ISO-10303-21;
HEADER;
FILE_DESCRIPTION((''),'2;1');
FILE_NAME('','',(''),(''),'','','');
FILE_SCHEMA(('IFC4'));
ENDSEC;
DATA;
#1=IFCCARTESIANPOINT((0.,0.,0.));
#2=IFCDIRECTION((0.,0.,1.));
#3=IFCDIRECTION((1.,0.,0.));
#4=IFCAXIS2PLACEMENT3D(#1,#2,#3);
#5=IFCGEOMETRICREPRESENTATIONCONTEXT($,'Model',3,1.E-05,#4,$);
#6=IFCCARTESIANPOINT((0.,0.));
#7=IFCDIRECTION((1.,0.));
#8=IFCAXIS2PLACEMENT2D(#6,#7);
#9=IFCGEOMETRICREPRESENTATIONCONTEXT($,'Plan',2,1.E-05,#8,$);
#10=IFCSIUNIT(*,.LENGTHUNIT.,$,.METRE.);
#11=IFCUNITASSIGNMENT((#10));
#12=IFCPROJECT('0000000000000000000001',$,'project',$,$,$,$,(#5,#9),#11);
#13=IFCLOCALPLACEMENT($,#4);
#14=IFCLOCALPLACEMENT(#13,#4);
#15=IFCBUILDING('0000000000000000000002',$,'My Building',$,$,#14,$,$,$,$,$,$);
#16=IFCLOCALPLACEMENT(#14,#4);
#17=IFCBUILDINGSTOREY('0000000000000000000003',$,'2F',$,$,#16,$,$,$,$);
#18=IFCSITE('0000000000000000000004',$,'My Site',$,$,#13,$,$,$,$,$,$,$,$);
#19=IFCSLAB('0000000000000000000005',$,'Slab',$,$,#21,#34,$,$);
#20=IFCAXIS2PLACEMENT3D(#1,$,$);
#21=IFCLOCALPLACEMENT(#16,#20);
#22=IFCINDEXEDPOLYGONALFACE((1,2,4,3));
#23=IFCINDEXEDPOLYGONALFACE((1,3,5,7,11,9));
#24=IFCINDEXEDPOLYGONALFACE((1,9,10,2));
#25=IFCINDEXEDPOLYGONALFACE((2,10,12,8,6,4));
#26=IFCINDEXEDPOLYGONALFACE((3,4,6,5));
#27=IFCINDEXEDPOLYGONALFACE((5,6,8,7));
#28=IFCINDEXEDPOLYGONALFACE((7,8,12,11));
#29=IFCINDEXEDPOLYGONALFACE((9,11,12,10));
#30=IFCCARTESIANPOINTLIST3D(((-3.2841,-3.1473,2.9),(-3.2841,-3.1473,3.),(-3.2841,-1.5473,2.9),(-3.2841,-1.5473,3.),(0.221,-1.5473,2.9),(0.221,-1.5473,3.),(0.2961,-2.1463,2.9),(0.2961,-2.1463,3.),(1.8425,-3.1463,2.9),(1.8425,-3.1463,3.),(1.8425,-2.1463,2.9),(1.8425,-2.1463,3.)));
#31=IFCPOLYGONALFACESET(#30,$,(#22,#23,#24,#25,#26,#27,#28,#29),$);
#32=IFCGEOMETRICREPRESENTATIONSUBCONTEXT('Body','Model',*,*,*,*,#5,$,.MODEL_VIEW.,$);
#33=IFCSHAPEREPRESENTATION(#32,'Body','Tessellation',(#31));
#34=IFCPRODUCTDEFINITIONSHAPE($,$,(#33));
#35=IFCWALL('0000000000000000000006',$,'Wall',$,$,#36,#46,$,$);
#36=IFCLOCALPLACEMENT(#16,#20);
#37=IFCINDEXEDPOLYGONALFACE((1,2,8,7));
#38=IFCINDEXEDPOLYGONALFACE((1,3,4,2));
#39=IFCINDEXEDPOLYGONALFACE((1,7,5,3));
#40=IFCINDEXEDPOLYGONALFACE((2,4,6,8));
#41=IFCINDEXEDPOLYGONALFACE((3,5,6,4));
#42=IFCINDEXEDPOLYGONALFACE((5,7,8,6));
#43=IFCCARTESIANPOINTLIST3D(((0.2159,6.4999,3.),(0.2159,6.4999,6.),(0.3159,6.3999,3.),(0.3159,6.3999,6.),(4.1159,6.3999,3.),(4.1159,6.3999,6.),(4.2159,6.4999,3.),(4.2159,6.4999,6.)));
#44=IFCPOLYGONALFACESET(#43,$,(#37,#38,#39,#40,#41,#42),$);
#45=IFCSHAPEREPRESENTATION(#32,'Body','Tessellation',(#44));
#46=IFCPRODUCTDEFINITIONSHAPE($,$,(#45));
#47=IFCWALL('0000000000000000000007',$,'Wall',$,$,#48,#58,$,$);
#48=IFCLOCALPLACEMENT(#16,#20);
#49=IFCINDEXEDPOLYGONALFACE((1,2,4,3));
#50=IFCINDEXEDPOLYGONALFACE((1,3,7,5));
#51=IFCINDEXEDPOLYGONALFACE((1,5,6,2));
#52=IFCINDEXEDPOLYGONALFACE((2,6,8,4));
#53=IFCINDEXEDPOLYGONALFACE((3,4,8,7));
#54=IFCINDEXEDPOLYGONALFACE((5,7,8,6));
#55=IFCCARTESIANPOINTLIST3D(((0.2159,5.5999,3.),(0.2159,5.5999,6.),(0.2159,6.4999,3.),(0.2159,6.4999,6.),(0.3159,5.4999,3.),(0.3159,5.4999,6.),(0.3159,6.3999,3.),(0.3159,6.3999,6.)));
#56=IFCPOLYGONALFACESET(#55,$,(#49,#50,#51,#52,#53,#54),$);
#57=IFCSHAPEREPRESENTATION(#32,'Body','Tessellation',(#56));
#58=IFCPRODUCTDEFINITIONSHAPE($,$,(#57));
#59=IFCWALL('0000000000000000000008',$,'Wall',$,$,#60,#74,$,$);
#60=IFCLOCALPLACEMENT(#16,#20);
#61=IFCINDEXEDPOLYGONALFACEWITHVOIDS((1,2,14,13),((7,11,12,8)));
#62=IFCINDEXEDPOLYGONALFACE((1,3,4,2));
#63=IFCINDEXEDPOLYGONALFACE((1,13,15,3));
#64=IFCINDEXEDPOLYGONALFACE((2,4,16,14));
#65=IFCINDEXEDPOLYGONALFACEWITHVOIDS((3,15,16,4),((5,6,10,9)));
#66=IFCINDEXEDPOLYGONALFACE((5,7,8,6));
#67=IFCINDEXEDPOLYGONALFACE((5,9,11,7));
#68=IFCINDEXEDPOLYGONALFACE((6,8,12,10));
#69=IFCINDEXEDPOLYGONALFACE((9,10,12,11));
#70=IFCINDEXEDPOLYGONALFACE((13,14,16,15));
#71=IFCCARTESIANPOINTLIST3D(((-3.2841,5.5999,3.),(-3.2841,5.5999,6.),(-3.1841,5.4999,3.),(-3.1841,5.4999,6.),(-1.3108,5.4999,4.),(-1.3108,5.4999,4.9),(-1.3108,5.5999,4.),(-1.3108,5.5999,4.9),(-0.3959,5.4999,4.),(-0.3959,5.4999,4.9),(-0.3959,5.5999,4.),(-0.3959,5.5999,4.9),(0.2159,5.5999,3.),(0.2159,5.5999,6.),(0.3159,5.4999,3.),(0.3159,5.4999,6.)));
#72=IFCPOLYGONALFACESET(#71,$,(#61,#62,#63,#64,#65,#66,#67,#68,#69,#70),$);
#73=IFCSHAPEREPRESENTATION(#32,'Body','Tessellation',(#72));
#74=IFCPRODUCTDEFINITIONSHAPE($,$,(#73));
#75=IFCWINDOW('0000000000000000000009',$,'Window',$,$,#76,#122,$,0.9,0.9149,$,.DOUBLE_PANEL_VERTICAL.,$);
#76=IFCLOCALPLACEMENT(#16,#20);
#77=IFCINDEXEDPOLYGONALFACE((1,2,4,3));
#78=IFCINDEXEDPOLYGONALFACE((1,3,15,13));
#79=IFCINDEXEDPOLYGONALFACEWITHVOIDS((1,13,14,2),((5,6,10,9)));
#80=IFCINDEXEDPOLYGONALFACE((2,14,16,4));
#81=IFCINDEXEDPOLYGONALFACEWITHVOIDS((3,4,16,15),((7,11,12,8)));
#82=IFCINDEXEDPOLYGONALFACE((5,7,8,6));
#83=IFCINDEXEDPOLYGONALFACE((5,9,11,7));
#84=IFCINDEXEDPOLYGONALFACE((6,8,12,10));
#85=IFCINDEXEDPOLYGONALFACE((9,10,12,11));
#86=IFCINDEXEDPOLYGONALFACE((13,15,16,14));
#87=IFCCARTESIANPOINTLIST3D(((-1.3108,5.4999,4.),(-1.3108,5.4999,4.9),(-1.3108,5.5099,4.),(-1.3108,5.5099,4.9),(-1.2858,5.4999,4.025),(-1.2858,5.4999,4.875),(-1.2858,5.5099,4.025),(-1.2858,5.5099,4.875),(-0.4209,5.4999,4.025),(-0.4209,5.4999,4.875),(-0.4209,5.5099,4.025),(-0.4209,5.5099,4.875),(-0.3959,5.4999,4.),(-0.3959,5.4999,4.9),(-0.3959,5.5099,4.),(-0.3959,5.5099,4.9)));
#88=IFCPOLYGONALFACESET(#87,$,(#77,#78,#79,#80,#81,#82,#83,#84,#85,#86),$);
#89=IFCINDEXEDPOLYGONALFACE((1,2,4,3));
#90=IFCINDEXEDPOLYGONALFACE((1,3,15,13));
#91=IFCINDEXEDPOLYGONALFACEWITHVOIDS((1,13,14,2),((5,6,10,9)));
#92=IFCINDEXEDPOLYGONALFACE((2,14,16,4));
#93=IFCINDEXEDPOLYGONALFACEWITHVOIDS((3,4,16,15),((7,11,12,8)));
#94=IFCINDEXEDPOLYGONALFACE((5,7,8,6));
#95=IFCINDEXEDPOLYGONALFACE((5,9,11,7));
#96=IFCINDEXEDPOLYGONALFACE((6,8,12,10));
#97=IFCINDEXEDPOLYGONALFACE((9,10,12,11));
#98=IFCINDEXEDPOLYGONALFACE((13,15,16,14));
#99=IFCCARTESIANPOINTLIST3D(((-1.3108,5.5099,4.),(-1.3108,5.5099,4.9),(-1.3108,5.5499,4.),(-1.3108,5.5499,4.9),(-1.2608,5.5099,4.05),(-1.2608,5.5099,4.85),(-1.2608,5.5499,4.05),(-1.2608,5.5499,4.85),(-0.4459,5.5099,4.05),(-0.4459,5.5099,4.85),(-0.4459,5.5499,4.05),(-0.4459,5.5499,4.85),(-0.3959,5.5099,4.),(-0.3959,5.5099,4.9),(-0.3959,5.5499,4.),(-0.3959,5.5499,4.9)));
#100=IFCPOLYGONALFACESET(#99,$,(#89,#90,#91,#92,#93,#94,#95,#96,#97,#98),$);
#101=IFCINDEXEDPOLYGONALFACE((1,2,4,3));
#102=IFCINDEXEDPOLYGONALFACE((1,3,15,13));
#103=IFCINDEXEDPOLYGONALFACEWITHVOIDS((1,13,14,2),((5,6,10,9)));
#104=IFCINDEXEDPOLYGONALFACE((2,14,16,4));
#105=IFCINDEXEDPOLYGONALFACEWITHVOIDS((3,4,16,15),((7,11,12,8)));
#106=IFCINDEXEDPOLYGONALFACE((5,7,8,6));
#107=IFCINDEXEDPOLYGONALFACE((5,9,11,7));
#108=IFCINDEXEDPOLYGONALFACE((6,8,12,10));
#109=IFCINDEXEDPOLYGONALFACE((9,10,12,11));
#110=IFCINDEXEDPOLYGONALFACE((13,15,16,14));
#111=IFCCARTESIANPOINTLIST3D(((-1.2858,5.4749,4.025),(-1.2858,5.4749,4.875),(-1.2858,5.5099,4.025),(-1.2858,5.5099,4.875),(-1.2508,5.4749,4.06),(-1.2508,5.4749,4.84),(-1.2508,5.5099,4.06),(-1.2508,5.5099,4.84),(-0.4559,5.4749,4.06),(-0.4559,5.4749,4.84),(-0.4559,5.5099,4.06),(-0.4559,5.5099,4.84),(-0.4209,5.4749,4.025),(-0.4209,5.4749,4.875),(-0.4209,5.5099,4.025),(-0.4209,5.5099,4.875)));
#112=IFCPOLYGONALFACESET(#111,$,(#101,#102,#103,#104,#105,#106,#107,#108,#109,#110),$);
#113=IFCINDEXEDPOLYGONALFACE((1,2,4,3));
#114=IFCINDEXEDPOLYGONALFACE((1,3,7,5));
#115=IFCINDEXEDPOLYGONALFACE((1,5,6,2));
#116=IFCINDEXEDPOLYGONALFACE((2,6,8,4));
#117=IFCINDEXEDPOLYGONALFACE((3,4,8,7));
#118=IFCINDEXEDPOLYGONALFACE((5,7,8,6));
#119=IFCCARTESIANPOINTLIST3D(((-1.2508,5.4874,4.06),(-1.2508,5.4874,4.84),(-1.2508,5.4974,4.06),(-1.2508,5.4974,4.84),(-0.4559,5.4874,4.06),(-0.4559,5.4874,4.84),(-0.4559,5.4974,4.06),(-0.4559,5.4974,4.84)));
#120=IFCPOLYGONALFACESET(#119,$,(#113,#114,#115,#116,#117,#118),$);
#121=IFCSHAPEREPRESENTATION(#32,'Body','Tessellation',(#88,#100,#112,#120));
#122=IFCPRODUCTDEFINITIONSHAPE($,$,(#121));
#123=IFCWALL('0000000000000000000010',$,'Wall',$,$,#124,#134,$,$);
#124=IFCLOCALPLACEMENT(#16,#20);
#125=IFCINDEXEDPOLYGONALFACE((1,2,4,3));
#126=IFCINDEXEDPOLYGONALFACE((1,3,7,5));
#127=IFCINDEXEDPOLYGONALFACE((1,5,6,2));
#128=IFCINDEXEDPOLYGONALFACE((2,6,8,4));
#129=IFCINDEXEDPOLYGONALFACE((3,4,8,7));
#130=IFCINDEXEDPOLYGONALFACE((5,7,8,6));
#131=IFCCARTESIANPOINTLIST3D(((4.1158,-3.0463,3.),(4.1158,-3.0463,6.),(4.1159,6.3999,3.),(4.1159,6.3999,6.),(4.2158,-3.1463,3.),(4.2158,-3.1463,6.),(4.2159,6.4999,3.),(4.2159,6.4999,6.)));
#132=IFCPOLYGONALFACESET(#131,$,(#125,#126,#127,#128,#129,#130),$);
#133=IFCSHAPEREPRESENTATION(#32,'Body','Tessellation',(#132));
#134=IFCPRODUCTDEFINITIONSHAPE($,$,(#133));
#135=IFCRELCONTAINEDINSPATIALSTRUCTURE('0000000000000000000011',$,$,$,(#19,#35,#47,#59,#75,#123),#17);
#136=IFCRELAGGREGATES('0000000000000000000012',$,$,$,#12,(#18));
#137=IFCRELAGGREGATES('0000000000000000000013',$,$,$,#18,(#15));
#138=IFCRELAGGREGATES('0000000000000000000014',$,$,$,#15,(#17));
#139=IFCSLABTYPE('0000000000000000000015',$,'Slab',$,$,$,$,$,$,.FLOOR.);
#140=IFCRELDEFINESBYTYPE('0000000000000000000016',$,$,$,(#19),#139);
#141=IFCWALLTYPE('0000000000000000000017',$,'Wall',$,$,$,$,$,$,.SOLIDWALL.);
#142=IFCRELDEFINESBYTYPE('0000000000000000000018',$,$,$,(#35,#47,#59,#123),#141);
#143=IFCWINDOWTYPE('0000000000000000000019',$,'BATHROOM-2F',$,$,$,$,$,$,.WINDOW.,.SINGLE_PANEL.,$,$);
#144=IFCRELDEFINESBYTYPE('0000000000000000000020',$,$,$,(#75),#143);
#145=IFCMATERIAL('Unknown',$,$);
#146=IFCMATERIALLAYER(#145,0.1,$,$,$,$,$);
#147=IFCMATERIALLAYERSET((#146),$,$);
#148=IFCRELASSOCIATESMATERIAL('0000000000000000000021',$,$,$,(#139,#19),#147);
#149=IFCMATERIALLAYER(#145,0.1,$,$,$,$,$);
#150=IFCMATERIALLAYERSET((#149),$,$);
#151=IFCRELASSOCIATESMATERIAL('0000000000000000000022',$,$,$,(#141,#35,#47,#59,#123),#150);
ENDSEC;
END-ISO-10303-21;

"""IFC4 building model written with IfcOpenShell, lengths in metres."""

from ifc_helpers import new_model, entity, si_unit, frame, origin_with_axes, origin_2d_with_axis, place, context, subcontext, project, spatial, line, indexed_curve, outline, extrude, shape, source, transform, mapped, material, layer, layer_set, layer_usage, type_object, type_shapes, element, fill, save


model = new_model("IFC4")

# Units and contexts
model_context = context("Model", 3, precision=1e-05, world=origin_with_axes())
plan_context = context("Plan", 2, precision=1e-05, world=origin_2d_with_axis())
body_context_1 = subcontext(model_context, "Body", "Model", "MODEL_VIEW")
body_context_2 = subcontext(plan_context, "Body", "Plan", "PLAN_VIEW")
ifc_project = project(units=[si_unit("LENGTHUNIT", "METRE")], contexts=[model_context, plan_context])

# Site, building, storey
site_placement = place(None, origin_with_axes())
site = spatial("IfcSite", under=ifc_project, at=site_placement, Name="My Site")
building_placement = place(site_placement, origin_with_axes())
building = spatial("IfcBuilding", under=site, at=building_placement, Name="My Building")
storey_placement = place(building_placement, origin_with_axes())
storey = spatial("IfcBuildingStorey", under=building, at=storey_placement, Name="2F")

# Slab
ifc_material = material(Name="Unknown")
ifc_layer_1 = layer(ifc_material, 0.1)
ifc_layer_set_1 = layer_set([ifc_layer_1])
ifc_layer_usage_1 = layer_usage(ifc_layer_set_1, "AXIS3", "POSITIVE", -0.1)
slab_type = type_object("IfcSlabType", Name="Slab", PredefinedType="FLOOR", material=ifc_layer_set_1)
slab_placement = place(storey_placement, frame((-3.2841, -1.5473, 3.0), z_axis=(0.0, 0.0, 1.0), x_axis=(1.0, 0.0, 0.0)))
element("IfcSlab", 1, at=slab_placement, inside=storey, type_object=slab_type, material=ifc_layer_usage_1, Name="Slab", context=body_context_1, shape_type="SweptSolid", body=[
    extrude(outline(indexed_curve([(0.0, 0.0), (0.0, -1.6), (5.1266, -1.599), (5.1266, -0.599), (3.5803, -0.599), (3.5052, 0.0), (0.0, 0.0)])), frame((0.0, 0.0, -0.1), z_axis=(0.0, 0.0, 1.0), x_axis=(1.0, 0.0, 0.0)), (0.0, 0.0, 1.0), 0.1),
])

# Walls
ifc_layer_2 = layer(ifc_material, 0.1)
ifc_layer_set_2 = layer_set([ifc_layer_2])
ifc_layer_usage_2 = layer_usage(ifc_layer_set_2, "AXIS2", "POSITIVE", 0.0)
wall_type = type_object("IfcWallType", Name="Wall", PredefinedType="SOLIDWALL", material=ifc_layer_set_2)
wall_1_placement = place(storey_placement, frame((4.2159, 6.4999, 3.0), z_axis=(0.0, 0.0, 1.0), x_axis=(-1.0, 0.0, 0.0)))
element("IfcWall", 2, at=wall_1_placement, inside=storey, type_object=wall_type, material=ifc_layer_usage_2, Name="Wall", context=body_context_1, shape_type="SweptSolid", body=[
    extrude(outline(indexed_curve([(0.0, 0.0), (0.1, 0.1), (3.9, 0.1), (4.0, 0.0)], segments=[line(1, 2, 3, 4, 1)])), origin_with_axes(), (0.0, 0.0, 1.0), 3.0),
])
ifc_layer_usage_3 = layer_usage(ifc_layer_set_2, "AXIS2", "POSITIVE", 0.0)
wall_2_placement = place(storey_placement, frame((0.2159, 6.4999, 3.0), z_axis=(0.0, 0.0, 1.0), x_axis=(0.0, -1.0, 0.0)))
element("IfcWall", 3, at=wall_2_placement, inside=storey, type_object=wall_type, material=ifc_layer_usage_3, Name="Wall", context=body_context_1, shape_type="SweptSolid", body=[
    extrude(outline(indexed_curve([(0.0, 0.0), (0.1, 0.1), (1.0, 0.1), (0.9, 0.0)], segments=[line(1, 2, 3, 4, 1)])), origin_with_axes(), (0.0, 0.0, 1.0), 3.0),
])

# Wall, opening, window
ifc_layer_usage_4 = layer_usage(ifc_layer_set_2, "AXIS2", "POSITIVE", 0.0)
wall_3_placement = place(storey_placement, frame((0.2159, 5.5999, 3.0), z_axis=(0.0, 0.0, 1.0), x_axis=(-1.0, 0.0, 0.0)))
wall_3 = element("IfcWall", 4, at=wall_3_placement, inside=storey, type_object=wall_type, material=ifc_layer_usage_4, Name="Wall", context=body_context_1, shape_type="SweptSolid", body=[
    extrude(outline(indexed_curve([(0.0, 0.0), (-0.1, 0.1), (3.4, 0.1), (3.5, 0.0)], segments=[line(1, 2, 3, 4, 1)])), origin_with_axes(), (0.0, 0.0, 1.0), 3.0),
])
shared_shape_1 = source(origin_with_axes(), body_context_1, "Body", "SweptSolid", [
    extrude(outline(indexed_curve([(0.0, 0.0), (0.9149, 0.0), (0.9149, 0.9), (0.0, 0.9)], segments=[line(1, 2, 3, 4, 1)])), frame((0.0, -0.6, 0.0), z_axis=(0.0, -1.0, 0.0), x_axis=(1.0, 0.0, 0.0)), (0.0, 0.0, -1.0), 1.2),
])
opening_1_placement = place(wall_3_placement, frame((0.6117, 0.0, 1.0), z_axis=(0.0, 0.0, 1.0), x_axis=(1.0, -0.000001, 0.0)))
opening_1 = element("IfcOpeningElement", 5, at=opening_1_placement, cuts=wall_3, PredefinedType="OPENING", context=body_context_1, shape_type="MappedRepresentation", body=[
    mapped(shared_shape_1, transform((0.0, 0.0, 0.0), x_axis=(1.0, 0.0, 0.0), y_axis=(0.0, 1.0, 0.0), z_axis=(0.0, 0.0, 1.0), scale=1.0)),
])
window_type_1 = type_object("IfcWindowType", Name="BATHROOM-2F", PartitioningType="SINGLE_PANEL", PredefinedType="WINDOW")
shared_shape_2 = source(origin_with_axes(), body_context_1, "Body", "SweptSolid", [
    extrude(outline(indexed_curve([(0.0, 0.0), (0.9149, 0.0), (0.9149, 0.9), (0.0, 0.9)], segments=[line(1, 2, 3, 4, 1)]), holes=[indexed_curve([(0.025, 0.025), (0.8899, 0.025), (0.8899, 0.875), (0.025, 0.875)], segments=[line(1, 2, 3, 4, 1)])]), frame((0.0, 0.09, 0.0), z_axis=(0.0, -1.0, 0.0), x_axis=(1.0, 0.0, 0.0)), (0.0, 0.0, -1.0), 0.01),
    extrude(outline(indexed_curve([(0.0, 0.0), (0.9149, 0.0), (0.9149, 0.9), (0.0, 0.9)], segments=[line(1, 2, 3, 4, 1)]), holes=[indexed_curve([(0.05, 0.05), (0.8649, 0.05), (0.8649, 0.85), (0.05, 0.85)], segments=[line(1, 2, 3, 4, 1)])]), frame((0.0, 0.05, 0.0), z_axis=(0.0, -1.0, 0.0), x_axis=(1.0, 0.0, 0.0)), (0.0, 0.0, -1.0), 0.04),
    extrude(outline(indexed_curve([(0.0, 0.0), (0.8649, 0.0), (0.8649, 0.85), (0.0, 0.85)], segments=[line(1, 2, 3, 4, 1)]), holes=[indexed_curve([(0.035, 0.035), (0.8299, 0.035), (0.8299, 0.815), (0.035, 0.815)], segments=[line(1, 2, 3, 4, 1)])]), frame((0.025, 0.09, 0.025), z_axis=(0.0, -1.0, 0.0), x_axis=(1.0, 0.0, 0.0)), (0.0, 0.0, -1.0), 0.035),
    extrude(outline(indexed_curve([(0.035, 0.035), (0.8299, 0.035), (0.8299, 0.815), (0.035, 0.815)], segments=[line(1, 2, 3, 4, 1)])), frame((0.025, 0.1025, 0.025), z_axis=(0.0, -1.0, 0.0), x_axis=(1.0, 0.0, 0.0)), (0.0, 0.0, -1.0), 0.01),
])
shared_shape_3 = source(origin_with_axes(), body_context_2, "Body", "Curve2D", [
    entity("IfcIndexedPolyCurve", entity("IfcCartesianPointList2D", [[0.05, 0.05], [0.8649, 0.05]])),
    entity("IfcIndexedPolyCurve", entity("IfcCartesianPointList2D", [[0.0, 0.1], [0.025, 0.1], [0.025, 0.09], [0.05, 0.09], [0.05, 0.05], [0.0, 0.05]]), [entity("IfcLineIndex", [1, 2, 3, 4, 5, 6, 1])]),
    entity("IfcIndexedPolyCurve", entity("IfcCartesianPointList2D", [[0.9149, 0.1], [0.8899, 0.1], [0.8899, 0.09], [0.8649, 0.09], [0.8649, 0.05], [0.9149, 0.05]]), [entity("IfcLineIndex", [1, 2, 3, 4, 5, 6, 1])]),
    entity("IfcIndexedPolyCurve", entity("IfcCartesianPointList2D", [[0.025, 0.09], [0.06, 0.09], [0.06, 0.125], [0.025, 0.125]]), [entity("IfcLineIndex", [1, 2, 3, 4, 1])]),
    entity("IfcIndexedPolyCurve", entity("IfcCartesianPointList2D", [[0.8899, 0.09], [0.8549, 0.09], [0.8549, 0.125], [0.8899, 0.125]]), [entity("IfcLineIndex", [1, 2, 3, 4, 1])]),
    entity("IfcIndexedPolyCurve", entity("IfcCartesianPointList2D", [[0.06, 0.09], [0.8549, 0.09]])),
    entity("IfcIndexedPolyCurve", entity("IfcCartesianPointList2D", [[0.06, 0.125], [0.8549, 0.125]])),
    entity("IfcIndexedPolyCurve", entity("IfcCartesianPointList2D", [[0.06, 0.1075], [0.8549, 0.1075]])),
])
type_shapes(window_type_1, [shared_shape_2, shared_shape_3])
window_1_placement = place(opening_1_placement, frame((0.0, 0.0, 0.0), z_axis=(0.0, 0.0, 1.0), x_axis=(1.0, 0.0, 0.0)))
window_1 = element("IfcWindow", 6, at=window_1_placement, inside=storey, type_object=window_type_1, Name="Window", OverallHeight=0.9, OverallWidth=0.9149, PartitioningType="DOUBLE_PANEL_VERTICAL", shapes=[
    shape(body_context_1, "Body", "MappedRepresentation", [mapped(shared_shape_2, transform((0.0, 0.0, 0.0), x_axis=(1.0, 0.0, 0.0), y_axis=(0.0, 1.0, 0.0), z_axis=(0.0, 0.0, 1.0), scale=1.0))]),
    shape(body_context_2, "Body", "MappedRepresentation", [mapped(shared_shape_3, transform((0.0, 0.0, 0.0), x_axis=(1.0, 0.0, 0.0), y_axis=(0.0, 1.0, 0.0), z_axis=(0.0, 0.0, 1.0), scale=1.0))]),
])
fill(opening_1, window_1)

# Wall
ifc_layer_usage_5 = layer_usage(ifc_layer_set_2, "AXIS2", "POSITIVE", 0.0)
wall_4_placement = place(storey_placement, frame((4.2158, -3.1463, 3.0), z_axis=(0.0, 0.0, 1.0), x_axis=(0.0, 1.0, 0.0)))
element("IfcWall", 7, at=wall_4_placement, inside=storey, type_object=wall_type, material=ifc_layer_usage_5, Name="Wall", context=body_context_1, shape_type="SweptSolid", body=[
    extrude(outline(indexed_curve([(0.0, 0.0), (0.1, 0.1), (9.5461, 0.1), (9.6461, 0.0)], segments=[line(1, 2, 3, 4, 1)])), origin_with_axes(), (0.0, 0.0, 1.0), 3.0),
])

save(model, "model.ifc")
